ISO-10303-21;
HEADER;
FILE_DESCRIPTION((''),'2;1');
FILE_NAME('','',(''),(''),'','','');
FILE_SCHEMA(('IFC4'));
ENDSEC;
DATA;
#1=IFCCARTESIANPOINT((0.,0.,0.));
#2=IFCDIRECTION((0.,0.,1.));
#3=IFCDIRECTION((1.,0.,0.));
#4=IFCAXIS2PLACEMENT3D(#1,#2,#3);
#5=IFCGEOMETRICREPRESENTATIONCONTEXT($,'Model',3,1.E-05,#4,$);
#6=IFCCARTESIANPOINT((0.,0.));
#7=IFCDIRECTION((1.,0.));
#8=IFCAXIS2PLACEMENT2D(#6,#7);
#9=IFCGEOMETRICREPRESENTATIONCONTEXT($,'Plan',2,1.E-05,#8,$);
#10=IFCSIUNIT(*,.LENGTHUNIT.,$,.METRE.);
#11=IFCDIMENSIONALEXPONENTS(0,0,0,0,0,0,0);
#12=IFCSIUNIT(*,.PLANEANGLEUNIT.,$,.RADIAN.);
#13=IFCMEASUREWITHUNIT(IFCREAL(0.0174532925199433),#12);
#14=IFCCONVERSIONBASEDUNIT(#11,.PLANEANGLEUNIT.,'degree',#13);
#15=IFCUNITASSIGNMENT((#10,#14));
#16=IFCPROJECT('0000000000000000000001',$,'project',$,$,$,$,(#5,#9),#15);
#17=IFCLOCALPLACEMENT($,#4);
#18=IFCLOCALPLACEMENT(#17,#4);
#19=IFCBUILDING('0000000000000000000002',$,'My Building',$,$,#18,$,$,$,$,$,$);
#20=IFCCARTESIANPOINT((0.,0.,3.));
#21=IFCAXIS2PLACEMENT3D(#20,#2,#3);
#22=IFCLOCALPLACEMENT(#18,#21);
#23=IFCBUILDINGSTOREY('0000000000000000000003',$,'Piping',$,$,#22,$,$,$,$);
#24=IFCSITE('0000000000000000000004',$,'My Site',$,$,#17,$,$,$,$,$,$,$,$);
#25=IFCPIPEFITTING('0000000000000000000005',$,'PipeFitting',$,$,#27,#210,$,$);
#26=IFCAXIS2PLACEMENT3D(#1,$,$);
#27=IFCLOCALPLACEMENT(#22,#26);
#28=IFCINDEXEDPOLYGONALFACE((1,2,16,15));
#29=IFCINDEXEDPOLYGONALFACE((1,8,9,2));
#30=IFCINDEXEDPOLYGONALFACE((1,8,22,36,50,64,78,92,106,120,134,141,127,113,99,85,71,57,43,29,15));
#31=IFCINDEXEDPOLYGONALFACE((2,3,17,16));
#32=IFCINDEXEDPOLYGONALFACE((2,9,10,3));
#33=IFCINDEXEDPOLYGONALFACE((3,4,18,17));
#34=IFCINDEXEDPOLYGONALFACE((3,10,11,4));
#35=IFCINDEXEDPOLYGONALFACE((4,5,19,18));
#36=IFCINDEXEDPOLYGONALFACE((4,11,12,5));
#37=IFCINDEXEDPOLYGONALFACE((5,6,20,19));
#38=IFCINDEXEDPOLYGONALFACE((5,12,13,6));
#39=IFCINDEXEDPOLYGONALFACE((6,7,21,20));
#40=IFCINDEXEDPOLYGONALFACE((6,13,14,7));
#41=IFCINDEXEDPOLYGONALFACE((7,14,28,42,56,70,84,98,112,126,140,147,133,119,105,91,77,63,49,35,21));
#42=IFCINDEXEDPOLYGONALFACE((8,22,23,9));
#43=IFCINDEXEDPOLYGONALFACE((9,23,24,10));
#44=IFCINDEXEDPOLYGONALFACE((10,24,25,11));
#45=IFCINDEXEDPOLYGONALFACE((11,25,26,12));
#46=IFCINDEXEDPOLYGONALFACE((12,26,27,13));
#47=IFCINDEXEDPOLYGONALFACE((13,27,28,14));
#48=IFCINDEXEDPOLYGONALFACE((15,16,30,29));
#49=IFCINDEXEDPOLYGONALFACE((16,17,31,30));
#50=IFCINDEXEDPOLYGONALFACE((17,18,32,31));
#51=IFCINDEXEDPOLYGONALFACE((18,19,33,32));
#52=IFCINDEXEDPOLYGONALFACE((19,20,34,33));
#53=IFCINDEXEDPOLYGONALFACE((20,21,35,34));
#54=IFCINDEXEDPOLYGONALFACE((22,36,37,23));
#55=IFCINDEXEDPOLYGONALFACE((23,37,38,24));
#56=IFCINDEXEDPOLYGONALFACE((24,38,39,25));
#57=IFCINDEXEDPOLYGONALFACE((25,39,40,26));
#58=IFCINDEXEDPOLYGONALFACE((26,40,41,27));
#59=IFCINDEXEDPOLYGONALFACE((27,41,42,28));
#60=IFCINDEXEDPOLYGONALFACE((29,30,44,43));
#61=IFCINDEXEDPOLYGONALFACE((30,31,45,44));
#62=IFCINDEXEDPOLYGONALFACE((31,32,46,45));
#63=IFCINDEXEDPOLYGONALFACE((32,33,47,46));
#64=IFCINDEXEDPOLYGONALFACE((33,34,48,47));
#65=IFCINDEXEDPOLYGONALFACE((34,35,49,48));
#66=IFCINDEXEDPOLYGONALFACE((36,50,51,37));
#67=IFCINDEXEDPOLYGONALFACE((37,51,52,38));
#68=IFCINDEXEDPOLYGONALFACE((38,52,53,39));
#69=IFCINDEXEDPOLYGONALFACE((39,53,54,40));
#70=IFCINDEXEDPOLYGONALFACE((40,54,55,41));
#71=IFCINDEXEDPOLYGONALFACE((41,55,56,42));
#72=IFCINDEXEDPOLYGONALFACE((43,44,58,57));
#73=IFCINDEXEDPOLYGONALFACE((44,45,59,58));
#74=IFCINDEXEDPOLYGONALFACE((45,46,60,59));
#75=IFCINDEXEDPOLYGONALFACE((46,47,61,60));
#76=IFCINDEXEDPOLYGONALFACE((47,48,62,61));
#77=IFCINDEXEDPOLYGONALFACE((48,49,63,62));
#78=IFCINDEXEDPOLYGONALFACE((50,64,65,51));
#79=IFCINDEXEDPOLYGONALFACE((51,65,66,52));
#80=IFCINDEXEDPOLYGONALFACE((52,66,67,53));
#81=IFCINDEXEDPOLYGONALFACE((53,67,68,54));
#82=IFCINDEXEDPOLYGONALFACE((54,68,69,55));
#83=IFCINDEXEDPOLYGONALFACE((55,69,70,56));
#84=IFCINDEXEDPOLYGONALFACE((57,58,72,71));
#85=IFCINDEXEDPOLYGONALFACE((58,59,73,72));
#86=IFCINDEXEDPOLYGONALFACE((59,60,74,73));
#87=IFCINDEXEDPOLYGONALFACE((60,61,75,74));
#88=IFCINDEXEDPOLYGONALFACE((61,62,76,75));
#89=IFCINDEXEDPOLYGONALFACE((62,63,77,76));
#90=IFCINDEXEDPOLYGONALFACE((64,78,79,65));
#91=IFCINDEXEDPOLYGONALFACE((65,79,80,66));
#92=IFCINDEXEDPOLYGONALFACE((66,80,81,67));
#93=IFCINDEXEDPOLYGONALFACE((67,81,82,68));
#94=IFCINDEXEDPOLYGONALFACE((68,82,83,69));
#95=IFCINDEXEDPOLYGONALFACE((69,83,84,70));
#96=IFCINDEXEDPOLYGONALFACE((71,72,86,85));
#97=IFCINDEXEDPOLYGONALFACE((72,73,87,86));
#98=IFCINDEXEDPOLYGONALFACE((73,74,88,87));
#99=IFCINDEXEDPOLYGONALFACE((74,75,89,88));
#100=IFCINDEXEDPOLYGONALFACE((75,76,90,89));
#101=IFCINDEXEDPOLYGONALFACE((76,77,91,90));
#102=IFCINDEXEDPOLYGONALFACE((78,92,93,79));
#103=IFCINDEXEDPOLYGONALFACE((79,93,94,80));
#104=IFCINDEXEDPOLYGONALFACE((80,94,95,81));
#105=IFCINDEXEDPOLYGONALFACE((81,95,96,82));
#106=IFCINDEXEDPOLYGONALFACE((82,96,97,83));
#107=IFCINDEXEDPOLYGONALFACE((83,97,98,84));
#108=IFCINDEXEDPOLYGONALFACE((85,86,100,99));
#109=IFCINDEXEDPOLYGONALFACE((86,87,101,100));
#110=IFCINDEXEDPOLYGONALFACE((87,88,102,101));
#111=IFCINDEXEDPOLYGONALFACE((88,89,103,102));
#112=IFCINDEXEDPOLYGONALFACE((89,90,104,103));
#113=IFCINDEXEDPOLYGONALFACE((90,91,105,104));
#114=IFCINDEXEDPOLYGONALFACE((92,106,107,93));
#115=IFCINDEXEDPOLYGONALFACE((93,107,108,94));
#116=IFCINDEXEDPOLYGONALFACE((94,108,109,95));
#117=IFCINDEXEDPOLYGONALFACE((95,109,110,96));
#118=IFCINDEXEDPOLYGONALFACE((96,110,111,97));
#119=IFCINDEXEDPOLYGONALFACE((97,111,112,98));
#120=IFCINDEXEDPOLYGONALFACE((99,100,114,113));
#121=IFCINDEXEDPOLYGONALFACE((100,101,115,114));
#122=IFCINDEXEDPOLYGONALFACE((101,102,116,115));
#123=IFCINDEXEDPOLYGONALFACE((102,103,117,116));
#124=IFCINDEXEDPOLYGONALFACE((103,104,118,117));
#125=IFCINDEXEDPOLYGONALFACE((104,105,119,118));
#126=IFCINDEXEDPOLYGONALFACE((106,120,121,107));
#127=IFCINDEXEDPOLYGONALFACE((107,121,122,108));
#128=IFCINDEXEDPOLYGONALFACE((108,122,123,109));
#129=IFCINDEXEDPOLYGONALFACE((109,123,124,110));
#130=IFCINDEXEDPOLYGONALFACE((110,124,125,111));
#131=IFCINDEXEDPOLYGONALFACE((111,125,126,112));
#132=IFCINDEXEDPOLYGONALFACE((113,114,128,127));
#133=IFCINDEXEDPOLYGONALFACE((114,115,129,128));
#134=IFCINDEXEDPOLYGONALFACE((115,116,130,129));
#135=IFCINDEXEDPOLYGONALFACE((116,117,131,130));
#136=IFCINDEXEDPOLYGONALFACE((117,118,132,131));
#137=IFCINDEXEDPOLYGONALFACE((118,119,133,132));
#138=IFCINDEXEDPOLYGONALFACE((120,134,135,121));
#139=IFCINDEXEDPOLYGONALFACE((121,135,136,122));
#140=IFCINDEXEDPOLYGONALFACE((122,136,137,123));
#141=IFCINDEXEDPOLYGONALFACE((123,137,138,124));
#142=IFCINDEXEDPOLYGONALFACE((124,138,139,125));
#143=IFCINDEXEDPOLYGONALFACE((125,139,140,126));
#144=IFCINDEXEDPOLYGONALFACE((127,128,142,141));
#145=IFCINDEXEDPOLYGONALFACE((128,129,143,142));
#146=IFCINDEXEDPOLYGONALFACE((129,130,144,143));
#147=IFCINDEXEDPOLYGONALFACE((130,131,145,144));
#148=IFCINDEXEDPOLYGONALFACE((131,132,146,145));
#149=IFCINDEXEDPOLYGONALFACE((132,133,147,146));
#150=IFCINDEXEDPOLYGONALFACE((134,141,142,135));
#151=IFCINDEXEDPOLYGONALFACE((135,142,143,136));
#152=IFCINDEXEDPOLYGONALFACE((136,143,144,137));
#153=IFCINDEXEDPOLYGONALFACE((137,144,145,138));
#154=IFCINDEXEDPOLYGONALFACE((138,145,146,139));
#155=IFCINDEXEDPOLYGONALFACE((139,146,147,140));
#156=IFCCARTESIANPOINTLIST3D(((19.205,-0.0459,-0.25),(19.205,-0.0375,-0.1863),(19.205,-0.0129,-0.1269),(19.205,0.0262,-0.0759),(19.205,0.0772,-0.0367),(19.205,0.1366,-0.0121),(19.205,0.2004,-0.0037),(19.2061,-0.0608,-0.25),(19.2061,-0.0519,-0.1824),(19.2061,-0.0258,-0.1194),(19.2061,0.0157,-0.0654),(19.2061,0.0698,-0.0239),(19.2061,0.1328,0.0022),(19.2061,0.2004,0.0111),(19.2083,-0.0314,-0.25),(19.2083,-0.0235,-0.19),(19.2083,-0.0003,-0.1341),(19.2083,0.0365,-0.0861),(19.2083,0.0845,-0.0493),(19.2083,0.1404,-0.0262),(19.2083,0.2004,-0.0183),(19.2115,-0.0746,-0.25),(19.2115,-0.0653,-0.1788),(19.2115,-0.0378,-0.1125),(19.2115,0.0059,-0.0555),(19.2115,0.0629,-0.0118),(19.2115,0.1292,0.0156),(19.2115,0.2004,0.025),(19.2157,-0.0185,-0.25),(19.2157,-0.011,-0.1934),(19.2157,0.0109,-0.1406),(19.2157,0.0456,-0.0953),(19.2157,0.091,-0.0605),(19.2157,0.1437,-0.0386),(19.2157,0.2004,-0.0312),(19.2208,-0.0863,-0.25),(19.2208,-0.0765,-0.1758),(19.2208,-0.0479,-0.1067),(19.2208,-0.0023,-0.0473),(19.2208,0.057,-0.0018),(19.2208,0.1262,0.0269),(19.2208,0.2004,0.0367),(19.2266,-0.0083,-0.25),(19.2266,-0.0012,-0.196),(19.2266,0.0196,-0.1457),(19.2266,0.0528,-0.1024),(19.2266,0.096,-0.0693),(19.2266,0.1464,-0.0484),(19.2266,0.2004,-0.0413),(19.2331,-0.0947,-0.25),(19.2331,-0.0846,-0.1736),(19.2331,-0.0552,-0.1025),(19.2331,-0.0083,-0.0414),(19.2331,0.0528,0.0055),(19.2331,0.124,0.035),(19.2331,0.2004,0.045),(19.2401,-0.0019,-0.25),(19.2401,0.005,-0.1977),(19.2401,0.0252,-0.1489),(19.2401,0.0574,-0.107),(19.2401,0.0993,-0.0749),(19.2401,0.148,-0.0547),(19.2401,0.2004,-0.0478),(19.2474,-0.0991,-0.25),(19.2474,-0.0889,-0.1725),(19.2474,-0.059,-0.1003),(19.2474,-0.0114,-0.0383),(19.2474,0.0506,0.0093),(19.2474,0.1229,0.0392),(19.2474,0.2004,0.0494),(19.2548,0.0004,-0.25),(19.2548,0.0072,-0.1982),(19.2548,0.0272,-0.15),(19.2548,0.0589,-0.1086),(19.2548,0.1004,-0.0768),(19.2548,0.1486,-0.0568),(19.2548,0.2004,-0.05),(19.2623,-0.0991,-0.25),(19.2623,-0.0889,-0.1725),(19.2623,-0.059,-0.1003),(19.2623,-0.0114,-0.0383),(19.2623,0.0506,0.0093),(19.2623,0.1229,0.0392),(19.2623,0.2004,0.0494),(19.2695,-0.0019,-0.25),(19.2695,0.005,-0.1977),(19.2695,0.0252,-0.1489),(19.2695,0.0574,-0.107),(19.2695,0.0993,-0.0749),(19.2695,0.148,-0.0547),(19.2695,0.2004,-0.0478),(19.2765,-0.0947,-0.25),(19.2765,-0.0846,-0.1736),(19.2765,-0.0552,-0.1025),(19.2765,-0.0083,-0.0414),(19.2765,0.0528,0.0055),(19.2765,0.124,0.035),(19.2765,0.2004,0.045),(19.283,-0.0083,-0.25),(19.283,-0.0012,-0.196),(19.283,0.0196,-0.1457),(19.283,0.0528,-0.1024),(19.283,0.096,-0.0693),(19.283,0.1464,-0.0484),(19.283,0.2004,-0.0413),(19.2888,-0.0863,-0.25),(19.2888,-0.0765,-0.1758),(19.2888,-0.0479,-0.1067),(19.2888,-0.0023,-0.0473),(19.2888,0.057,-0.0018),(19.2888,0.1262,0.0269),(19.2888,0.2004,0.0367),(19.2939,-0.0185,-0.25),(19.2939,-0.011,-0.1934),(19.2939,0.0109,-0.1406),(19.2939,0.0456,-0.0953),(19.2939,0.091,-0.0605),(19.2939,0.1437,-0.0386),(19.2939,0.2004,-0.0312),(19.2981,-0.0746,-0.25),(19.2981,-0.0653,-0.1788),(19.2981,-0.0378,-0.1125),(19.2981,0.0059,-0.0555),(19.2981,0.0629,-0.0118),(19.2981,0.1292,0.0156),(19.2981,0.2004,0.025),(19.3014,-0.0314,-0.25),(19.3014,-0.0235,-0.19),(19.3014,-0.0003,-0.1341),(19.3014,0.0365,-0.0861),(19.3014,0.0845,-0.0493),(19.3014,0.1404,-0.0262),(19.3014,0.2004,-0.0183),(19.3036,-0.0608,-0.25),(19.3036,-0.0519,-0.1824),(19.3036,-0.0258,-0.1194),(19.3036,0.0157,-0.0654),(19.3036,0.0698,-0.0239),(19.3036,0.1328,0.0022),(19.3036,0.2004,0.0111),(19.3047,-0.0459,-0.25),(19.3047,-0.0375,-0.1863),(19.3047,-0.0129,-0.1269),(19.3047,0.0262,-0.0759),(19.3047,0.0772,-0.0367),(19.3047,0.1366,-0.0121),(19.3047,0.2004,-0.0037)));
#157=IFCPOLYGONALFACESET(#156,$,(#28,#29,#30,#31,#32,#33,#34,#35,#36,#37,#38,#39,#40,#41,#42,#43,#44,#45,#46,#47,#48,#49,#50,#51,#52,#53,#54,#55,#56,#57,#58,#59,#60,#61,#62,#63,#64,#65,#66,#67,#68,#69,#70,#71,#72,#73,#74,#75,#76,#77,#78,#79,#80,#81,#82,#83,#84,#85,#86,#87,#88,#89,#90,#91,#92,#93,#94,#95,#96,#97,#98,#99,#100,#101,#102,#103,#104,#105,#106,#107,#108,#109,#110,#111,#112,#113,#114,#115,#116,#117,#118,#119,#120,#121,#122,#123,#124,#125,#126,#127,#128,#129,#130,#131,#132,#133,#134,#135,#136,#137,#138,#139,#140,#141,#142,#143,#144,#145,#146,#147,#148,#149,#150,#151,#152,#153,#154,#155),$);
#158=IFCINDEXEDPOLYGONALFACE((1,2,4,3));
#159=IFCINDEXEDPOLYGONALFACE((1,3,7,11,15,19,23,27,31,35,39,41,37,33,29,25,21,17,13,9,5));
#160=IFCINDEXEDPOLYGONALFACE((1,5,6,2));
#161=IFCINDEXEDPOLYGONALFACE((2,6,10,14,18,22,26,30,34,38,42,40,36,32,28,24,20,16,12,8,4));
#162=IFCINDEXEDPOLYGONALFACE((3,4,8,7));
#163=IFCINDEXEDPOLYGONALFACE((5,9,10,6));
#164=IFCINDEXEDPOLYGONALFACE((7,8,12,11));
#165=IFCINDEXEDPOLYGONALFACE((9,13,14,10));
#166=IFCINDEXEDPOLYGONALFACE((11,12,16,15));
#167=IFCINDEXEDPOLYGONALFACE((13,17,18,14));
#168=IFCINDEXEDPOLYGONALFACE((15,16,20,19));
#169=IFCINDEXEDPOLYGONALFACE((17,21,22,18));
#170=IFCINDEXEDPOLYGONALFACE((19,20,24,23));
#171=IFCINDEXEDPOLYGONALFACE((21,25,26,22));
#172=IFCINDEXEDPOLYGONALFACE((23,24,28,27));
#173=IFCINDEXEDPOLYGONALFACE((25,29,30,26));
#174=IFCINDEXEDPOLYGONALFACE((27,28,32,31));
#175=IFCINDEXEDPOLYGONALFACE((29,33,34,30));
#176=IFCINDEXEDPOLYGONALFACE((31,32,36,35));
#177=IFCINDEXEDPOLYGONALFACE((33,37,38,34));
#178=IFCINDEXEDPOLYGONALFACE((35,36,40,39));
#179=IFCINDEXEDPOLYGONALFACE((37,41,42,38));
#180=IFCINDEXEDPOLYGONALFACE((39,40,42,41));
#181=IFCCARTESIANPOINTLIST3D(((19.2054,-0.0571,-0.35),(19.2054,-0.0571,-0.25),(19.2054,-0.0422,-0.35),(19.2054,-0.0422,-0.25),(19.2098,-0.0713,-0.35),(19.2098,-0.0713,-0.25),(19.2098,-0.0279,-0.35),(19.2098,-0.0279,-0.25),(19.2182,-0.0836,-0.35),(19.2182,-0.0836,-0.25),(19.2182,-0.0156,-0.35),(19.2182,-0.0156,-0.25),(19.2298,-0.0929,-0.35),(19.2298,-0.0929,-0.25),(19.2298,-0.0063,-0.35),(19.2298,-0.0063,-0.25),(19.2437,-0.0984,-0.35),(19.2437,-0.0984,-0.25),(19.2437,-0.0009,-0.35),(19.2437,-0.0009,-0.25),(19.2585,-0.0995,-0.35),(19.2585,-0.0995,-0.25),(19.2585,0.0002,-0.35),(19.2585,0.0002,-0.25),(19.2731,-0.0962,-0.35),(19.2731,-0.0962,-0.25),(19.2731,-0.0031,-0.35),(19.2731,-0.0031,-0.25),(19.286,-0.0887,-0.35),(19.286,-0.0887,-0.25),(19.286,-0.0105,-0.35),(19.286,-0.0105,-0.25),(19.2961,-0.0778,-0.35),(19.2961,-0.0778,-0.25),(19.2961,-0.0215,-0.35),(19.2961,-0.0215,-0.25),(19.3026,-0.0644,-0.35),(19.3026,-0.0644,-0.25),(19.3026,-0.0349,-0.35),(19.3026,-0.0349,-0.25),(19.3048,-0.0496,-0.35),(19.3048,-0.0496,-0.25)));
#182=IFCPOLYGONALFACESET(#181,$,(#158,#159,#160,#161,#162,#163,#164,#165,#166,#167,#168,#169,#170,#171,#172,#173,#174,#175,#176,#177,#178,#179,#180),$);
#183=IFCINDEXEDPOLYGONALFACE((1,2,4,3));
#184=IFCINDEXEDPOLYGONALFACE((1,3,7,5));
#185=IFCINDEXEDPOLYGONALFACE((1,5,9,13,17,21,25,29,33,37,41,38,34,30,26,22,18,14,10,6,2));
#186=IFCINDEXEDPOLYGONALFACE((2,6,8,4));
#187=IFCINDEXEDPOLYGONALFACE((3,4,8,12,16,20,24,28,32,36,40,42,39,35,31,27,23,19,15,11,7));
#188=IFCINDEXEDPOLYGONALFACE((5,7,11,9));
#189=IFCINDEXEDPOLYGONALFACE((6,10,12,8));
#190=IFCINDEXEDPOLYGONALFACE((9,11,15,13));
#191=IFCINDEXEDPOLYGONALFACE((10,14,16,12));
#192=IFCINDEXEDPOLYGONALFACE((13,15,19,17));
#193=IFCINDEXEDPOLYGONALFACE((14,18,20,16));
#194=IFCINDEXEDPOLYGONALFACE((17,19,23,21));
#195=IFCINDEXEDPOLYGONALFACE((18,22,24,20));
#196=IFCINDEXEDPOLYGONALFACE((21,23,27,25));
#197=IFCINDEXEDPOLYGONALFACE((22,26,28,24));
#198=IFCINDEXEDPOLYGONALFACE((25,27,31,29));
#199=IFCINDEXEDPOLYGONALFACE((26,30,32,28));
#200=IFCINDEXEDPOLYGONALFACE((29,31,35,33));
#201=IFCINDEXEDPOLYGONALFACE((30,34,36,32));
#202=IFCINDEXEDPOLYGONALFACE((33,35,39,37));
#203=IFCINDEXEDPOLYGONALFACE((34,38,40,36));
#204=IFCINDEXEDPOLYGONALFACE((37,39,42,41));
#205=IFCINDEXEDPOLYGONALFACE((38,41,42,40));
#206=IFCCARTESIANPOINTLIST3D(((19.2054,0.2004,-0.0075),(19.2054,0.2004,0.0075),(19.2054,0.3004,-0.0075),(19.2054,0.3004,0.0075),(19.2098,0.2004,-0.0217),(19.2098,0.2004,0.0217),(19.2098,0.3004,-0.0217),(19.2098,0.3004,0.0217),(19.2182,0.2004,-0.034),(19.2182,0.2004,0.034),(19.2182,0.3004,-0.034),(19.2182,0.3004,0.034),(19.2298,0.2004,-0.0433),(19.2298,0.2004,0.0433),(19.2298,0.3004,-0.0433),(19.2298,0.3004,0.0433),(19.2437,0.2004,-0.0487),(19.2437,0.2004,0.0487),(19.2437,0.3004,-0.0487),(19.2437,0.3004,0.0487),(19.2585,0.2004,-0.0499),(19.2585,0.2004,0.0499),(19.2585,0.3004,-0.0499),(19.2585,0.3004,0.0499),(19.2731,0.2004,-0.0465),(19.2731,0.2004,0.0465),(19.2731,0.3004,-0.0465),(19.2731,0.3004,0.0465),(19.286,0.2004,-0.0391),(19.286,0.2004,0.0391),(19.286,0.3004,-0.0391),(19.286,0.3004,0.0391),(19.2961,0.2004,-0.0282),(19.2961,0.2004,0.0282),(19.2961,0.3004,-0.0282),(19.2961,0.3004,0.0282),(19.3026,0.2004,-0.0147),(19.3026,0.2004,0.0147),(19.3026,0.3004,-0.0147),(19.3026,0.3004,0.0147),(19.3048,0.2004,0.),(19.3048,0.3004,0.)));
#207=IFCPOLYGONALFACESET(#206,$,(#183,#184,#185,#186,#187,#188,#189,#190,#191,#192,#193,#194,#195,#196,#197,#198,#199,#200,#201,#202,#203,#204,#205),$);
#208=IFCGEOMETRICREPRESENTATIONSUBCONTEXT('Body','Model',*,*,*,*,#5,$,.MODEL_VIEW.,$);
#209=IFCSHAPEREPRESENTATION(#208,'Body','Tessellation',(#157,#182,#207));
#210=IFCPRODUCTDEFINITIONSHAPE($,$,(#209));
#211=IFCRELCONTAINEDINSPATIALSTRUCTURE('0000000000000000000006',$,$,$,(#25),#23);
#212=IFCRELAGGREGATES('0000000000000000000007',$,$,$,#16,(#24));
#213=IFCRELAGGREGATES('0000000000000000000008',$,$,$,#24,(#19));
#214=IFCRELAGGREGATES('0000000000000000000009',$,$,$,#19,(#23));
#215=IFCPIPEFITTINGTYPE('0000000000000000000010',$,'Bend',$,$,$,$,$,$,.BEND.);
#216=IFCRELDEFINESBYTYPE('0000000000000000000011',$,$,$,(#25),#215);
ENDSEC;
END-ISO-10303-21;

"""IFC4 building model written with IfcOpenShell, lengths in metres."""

from ifc_helpers import new_model, entity, si_unit, converted_unit, frame, origin_with_axes, origin_2d_with_axis, place, context, subcontext, project, spatial, circle, extrude, source, transform, mapped, type_object, type_shapes, element, save


model = new_model("IFC4")

# Units and contexts
model_context = context("Model", 3, precision=1e-05, world=origin_with_axes())
plan_context = context("Plan", 2, precision=1e-05, world=origin_2d_with_axis())
body_context = subcontext(model_context, "Body", "Model", "MODEL_VIEW")
ifc_project = project(units=[si_unit("LENGTHUNIT", "METRE"), converted_unit("PLANEANGLEUNIT", "degree", entity("IfcReal", 0.0174532925199433), si_unit("PLANEANGLEUNIT", "RADIAN"), dimensions=[0, 0, 0, 0, 0, 0, 0])], contexts=[model_context, plan_context])

# Site, building, storey
site_placement = place(None, origin_with_axes())
site = spatial("IfcSite", under=ifc_project, at=site_placement, Name="My Site")
building_placement = place(site_placement, origin_with_axes())
building = spatial("IfcBuilding", under=site, at=building_placement, Name="My Building")
storey_placement = place(building_placement, frame((0.0, 0.0, 3.0), z_axis=(0.0, 0.0, 1.0), x_axis=(1.0, 0.0, 0.0)))
storey = spatial("IfcBuildingStorey", under=building, at=storey_placement, Name="Piping")

# Shared definitions
pipe_fitting_type = type_object("IfcPipeFittingType", Name="Bend", PredefinedType="BEND")
shared_shape = source(origin_with_axes(), body_context, "Body", "SolidModel", [
    entity("IfcSweptDiskSolid", entity("IfcIndexedPolyCurve", entity("IfcCartesianPointList3D", [[0.0, 0.0, -0.1], [0.0, -0.0732, -0.2768], [0.0, -0.25, -0.35]]), [entity("IfcArcIndex", [1, 2, 3])]), 0.05),
    extrude(circle(Radius=0.05), origin_with_axes(), (0.0, 0.0, -1.0), 0.1),
    extrude(circle(Radius=0.05), frame((0.0, -0.25, -0.35), z_axis=(0.0, -1.0, 0.0), x_axis=(1.0, 0.0, 0.0)), (0.0, 0.0, 1.0), 0.1),
])
type_shapes(pipe_fitting_type, [shared_shape])

# Pipe fitting
for number, where, z_axis, x_axis, name in (
    (1, (19.2548, -0.0496, -0.35), (0.0, 0.0, -1.0), (1.0, 0.0, 0.0), "PipeFitting"),
):
    element("IfcPipeFitting", number, at=place(storey_placement, frame(where, z_axis=z_axis, x_axis=x_axis)), inside=storey, type_object=pipe_fitting_type, Name=name, context=body_context, shape_type="MappedRepresentation", body=[
        mapped(shared_shape, transform((0.0, 0.0, 0.0), x_axis=(1.0, 0.0, 0.0), y_axis=(0.0, 1.0, 0.0), z_axis=(0.0, 0.0, 1.0), scale=1.0)),
    ])

save(model, "model.ifc")
